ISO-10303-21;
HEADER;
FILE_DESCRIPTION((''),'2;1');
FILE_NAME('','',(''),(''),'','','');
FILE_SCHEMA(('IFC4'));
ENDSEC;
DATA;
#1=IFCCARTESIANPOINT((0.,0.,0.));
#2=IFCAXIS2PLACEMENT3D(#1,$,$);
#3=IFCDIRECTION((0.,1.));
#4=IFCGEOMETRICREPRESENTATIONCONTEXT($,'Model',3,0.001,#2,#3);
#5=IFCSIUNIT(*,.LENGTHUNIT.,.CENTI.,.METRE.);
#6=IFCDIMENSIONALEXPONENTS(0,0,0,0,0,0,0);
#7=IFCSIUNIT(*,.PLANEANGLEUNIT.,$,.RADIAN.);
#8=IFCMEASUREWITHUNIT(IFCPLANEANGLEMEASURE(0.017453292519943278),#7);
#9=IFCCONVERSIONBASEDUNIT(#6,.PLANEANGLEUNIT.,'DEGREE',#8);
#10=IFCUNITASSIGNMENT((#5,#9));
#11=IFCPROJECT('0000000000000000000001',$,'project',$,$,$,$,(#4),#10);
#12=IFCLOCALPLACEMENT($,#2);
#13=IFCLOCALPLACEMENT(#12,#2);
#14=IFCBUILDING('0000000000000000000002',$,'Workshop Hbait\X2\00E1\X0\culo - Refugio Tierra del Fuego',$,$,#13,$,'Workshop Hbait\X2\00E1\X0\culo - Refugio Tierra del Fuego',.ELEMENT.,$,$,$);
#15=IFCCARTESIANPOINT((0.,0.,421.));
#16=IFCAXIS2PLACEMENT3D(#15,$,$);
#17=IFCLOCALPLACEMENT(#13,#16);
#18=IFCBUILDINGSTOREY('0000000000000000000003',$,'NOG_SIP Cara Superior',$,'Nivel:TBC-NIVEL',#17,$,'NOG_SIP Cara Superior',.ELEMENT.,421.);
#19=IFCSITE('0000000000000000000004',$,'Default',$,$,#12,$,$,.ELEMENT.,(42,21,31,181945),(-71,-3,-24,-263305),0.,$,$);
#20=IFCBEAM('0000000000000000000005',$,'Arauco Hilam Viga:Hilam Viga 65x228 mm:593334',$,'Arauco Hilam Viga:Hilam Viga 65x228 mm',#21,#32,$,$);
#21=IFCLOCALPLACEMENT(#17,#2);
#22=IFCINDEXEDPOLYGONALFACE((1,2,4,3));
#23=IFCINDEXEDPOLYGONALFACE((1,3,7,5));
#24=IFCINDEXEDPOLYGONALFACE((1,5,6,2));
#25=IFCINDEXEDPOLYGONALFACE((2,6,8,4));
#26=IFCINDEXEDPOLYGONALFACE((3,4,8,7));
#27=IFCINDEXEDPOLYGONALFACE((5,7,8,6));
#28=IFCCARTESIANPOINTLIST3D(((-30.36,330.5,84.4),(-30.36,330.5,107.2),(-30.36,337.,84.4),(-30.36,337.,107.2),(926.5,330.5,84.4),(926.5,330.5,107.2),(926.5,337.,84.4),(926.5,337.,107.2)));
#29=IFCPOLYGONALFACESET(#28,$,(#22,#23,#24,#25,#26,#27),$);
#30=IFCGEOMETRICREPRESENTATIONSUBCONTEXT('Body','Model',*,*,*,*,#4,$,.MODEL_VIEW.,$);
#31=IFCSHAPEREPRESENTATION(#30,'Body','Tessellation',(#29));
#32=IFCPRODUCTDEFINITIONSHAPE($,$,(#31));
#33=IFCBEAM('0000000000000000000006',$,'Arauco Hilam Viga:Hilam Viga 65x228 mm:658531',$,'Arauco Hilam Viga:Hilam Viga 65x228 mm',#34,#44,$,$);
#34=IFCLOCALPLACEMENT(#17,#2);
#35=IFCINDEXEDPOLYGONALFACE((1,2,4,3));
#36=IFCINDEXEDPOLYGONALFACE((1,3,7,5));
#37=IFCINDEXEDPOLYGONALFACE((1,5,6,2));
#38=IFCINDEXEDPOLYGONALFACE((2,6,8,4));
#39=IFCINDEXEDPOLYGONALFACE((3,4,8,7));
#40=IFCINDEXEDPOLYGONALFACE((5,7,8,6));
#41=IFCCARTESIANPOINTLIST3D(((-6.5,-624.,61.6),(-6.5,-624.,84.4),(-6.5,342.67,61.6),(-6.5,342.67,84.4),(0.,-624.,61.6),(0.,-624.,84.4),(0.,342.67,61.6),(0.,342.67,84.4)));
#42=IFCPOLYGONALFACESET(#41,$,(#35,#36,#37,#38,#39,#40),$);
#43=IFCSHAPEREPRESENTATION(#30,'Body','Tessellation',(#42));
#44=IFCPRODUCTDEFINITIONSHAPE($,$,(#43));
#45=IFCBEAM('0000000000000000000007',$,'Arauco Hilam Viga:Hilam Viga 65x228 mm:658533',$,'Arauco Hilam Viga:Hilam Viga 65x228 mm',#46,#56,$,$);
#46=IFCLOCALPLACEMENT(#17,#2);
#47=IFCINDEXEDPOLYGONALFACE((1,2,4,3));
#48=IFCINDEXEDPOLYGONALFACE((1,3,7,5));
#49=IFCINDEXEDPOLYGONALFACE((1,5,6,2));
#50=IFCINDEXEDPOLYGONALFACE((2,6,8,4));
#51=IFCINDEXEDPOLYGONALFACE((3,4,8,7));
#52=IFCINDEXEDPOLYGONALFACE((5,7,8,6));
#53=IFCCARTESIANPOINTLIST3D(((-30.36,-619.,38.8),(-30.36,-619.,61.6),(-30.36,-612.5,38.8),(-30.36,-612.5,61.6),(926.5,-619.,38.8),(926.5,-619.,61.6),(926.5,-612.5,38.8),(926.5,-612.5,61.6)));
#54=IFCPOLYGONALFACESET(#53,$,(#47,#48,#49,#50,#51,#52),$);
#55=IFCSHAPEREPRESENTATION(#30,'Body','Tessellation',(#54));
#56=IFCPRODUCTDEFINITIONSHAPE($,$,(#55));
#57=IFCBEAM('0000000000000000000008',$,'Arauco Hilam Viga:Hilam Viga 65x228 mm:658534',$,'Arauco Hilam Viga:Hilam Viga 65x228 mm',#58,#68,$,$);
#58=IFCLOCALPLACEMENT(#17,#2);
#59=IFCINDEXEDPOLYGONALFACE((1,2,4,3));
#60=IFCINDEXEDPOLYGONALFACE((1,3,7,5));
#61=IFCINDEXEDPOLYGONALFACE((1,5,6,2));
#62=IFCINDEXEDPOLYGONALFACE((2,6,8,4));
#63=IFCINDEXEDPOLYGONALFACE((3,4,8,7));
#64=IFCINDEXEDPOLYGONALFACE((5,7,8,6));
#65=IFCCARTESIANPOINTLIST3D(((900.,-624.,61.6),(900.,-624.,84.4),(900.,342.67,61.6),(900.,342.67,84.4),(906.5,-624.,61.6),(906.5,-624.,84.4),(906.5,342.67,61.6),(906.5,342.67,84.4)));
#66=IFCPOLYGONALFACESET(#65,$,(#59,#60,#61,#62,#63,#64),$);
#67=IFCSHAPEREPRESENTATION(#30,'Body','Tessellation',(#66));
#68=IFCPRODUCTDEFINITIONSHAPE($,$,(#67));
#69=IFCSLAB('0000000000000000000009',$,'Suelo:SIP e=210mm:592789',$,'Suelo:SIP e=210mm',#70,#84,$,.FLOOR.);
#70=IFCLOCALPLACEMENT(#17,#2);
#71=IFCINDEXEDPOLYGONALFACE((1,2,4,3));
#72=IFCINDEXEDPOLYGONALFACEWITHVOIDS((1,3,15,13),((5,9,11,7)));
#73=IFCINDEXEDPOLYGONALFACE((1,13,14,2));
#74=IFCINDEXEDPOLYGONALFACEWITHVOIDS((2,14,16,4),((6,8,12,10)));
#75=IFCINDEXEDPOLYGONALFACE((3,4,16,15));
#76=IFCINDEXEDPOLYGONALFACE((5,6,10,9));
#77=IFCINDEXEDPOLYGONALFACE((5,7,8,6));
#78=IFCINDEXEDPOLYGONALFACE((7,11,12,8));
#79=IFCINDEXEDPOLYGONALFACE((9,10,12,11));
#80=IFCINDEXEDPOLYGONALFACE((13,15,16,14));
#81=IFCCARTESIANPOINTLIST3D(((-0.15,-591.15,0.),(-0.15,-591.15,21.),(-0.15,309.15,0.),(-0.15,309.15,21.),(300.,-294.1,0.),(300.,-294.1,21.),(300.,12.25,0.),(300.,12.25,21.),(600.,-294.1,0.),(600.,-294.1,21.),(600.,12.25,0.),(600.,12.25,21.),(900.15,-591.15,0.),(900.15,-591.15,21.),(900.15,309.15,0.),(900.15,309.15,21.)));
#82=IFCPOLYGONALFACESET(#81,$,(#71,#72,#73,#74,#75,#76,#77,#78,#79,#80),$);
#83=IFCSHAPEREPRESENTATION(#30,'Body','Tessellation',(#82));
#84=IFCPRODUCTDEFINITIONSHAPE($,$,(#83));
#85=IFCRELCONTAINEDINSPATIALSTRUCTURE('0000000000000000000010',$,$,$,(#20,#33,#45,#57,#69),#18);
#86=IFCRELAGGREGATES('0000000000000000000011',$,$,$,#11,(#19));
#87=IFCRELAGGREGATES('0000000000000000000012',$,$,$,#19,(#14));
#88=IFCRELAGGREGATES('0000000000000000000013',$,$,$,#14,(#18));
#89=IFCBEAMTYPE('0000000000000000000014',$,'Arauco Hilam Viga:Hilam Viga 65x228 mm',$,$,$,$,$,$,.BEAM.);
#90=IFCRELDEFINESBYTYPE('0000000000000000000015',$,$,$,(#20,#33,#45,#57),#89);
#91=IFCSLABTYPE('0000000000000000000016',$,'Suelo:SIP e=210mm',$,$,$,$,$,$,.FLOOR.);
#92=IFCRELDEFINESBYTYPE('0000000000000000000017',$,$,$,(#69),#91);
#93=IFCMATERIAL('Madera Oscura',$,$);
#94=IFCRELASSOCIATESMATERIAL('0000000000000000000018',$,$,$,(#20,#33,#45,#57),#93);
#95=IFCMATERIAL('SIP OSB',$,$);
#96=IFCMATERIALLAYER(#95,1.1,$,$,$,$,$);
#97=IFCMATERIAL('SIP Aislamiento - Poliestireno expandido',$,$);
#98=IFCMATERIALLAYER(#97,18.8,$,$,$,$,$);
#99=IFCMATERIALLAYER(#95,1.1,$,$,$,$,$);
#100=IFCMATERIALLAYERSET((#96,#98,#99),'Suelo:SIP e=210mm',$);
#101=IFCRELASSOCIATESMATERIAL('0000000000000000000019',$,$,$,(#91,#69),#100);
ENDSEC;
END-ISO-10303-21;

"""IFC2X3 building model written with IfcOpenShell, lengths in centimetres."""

from ifc_helpers import new_model, entity, si_unit, converted_unit, direction, frame, frame_2d, origin, origin_2d_with_axis, place, context, subcontext, project, spatial, rectangle, extrude, boolean, material, layer, layer_set, layer_usage, type_object, element, save


model = new_model("IFC2X3")

# Units and contexts
model_context = context("Model", 3, precision=0.001, world=origin(), true_north=direction((0.0, 1.0)))
body_context = subcontext(model_context, "Body", "Model", "MODEL_VIEW")
ifc_project = project(units=[si_unit("LENGTHUNIT", "METRE", prefix="CENTI"), converted_unit("PLANEANGLEUNIT", "DEGREE", entity("IfcPlaneAngleMeasure", 0.017453292519943278), si_unit("PLANEANGLEUNIT", "RADIAN"), dimensions=[0, 0, 0, 0, 0, 0, 0])], contexts=[model_context])

# Site, building, storey
site_placement = place(None, origin())
site = spatial("IfcSite", under=ifc_project, at=site_placement, Name="Default", CompositionType="ELEMENT", RefLatitude=(42, 21, 31, 181945), RefLongitude=(-71, -3, -24, -263305), RefElevation=0.0)
building_placement = place(site_placement, origin())
building = spatial("IfcBuilding", under=site, at=building_placement, Name="Workshop Hbaitáculo - Refugio Tierra del Fuego", LongName="Workshop Hbaitáculo - Refugio Tierra del Fuego", CompositionType="ELEMENT")
storey_placement = place(building_placement, frame((0.0, 0.0, 421.0)))
storey = spatial("IfcBuildingStorey", under=building, at=storey_placement, Name="NOG_SIP Cara Superior", ObjectType="Nivel:TBC-NIVEL", LongName="NOG_SIP Cara Superior", CompositionType="ELEMENT", Elevation=421.0)

# Beams
ifc_material_1 = material(Name="Madera Oscura")
beam_type = type_object("IfcBeamType", Name="Arauco Hilam Viga:Hilam Viga 65x228 mm", PredefinedType="BEAM")
beam_1_placement = place(storey_placement, frame((-96.14, 333.75, 107.2)))
element("IfcBeam", 1, at=beam_1_placement, inside=storey, type_object=beam_type, material=ifc_material_1, Name="Arauco Hilam Viga:Hilam Viga 65x228 mm:593334", ObjectType="Arauco Hilam Viga:Hilam Viga 65x228 mm", context=body_context, shape_type="SweptSolid", body=[
    extrude(rectangle(XDim=22.8, YDim=6.5, at=frame_2d((0.0, 0.0), x_axis=(1.0, 0.0))), frame((65.78, 0.0, -11.4), z_axis=(1.0, 0.0, 0.0), x_axis=(0.0, 0.0, -1.0)), (0.0, 0.0, 1.0), 956.86),
])
beam_2_placement = place(storey_placement, frame((-3.25, 318.11, 84.4), z_axis=(0.0, 0.0, 1.0), x_axis=(0.0, -1.0, 0.0)))
element("IfcBeam", 2, at=beam_2_placement, inside=storey, type_object=beam_type, material=ifc_material_1, Name="Arauco Hilam Viga:Hilam Viga 65x228 mm:658531", ObjectType="Arauco Hilam Viga:Hilam Viga 65x228 mm", context=body_context, shape_type="SweptSolid", body=[
    extrude(rectangle(XDim=22.8, YDim=6.5, at=frame_2d((0.0, 0.0), x_axis=(1.0, 0.0))), frame((-24.56, 0.0, -11.4), z_axis=(1.0, 0.0, 0.0), x_axis=(0.0, 0.0, -1.0)), (0.0, 0.0, 1.0), 966.67),
])
beam_3_placement = place(storey_placement, frame((-96.14, -615.75, 61.6)))
element("IfcBeam", 3, at=beam_3_placement, inside=storey, type_object=beam_type, material=ifc_material_1, Name="Arauco Hilam Viga:Hilam Viga 65x228 mm:658533", ObjectType="Arauco Hilam Viga:Hilam Viga 65x228 mm", context=body_context, shape_type="SweptSolid", body=[
    extrude(rectangle(XDim=22.8, YDim=6.5, at=origin_2d_with_axis()), frame((65.78, 0.0, -11.4), z_axis=(1.0, 0.0, 0.0), x_axis=(0.0, 0.0, -1.0)), (0.0, 0.0, 1.0), 956.86),
])
beam_4_placement = place(storey_placement, frame((903.25, 318.11, 84.4), z_axis=(0.0, 0.0, 1.0), x_axis=(0.0, -1.0, 0.0)))
element("IfcBeam", 4, at=beam_4_placement, inside=storey, type_object=beam_type, material=ifc_material_1, Name="Arauco Hilam Viga:Hilam Viga 65x228 mm:658534", ObjectType="Arauco Hilam Viga:Hilam Viga 65x228 mm", context=body_context, shape_type="SweptSolid", body=[
    extrude(rectangle(XDim=22.8, YDim=6.5, at=frame_2d((0.0, 0.0), x_axis=(1.0, 0.0))), frame((-24.56, 0.0, -11.4), z_axis=(1.0, 0.0, 0.0), x_axis=(0.0, 0.0, -1.0)), (0.0, 0.0, 1.0), 966.67),
])

# Slab, opening
ifc_material_2 = material(Name="SIP OSB")
ifc_layer_1 = layer(ifc_material_2, 1.1)
ifc_material_3 = material(Name="SIP Aislamiento - Poliestireno expandido")
ifc_layer_2 = layer(ifc_material_3, 18.8)
ifc_layer_3 = layer(ifc_material_2, 1.1)
ifc_layer_set = layer_set([ifc_layer_1, ifc_layer_2, ifc_layer_3], Name="Suelo:SIP e=210mm")
ifc_layer_usage = layer_usage(ifc_layer_set, "AXIS3", "POSITIVE", 0.0)
slab_type = type_object("IfcSlabType", Name="Suelo:SIP e=210mm", PredefinedType="FLOOR", material=ifc_layer_set)
slab_placement = place(storey_placement, origin())
slab = element("IfcSlab", 5, at=slab_placement, inside=storey, type_object=slab_type, material=ifc_layer_usage, Name="Suelo:SIP e=210mm:592789", ObjectType="Suelo:SIP e=210mm", PredefinedType="FLOOR", context=body_context, shape_type="CSG", body=[
    boolean("DIFFERENCE", extrude(rectangle(XDim=900.3, YDim=900.3, at=origin_2d_with_axis()), frame((450.0, -141.0, 21.0), z_axis=(0.0, 0.0, -1.0), x_axis=(0.0, 1.0, 0.0)), (0.0, 0.0, 1.0), 21.0), extrude(rectangle(XDim=306.35, YDim=300.0, at=frame_2d((0.0, 0.0), x_axis=(1.0, 0.0))), frame((450.0, -140.93, 0.0), z_axis=(0.0, 0.0, 1.0), x_axis=(0.0, 1.0, 0.0)), (0.0, 0.0, 1.0), 21.0)),
])
opening_placement = place(slab_placement, origin())
element("IfcOpeningElement", 6, at=opening_placement, cuts=slab, ObjectType="Opening", context=body_context, shape_type="SweptSolid", body=[
    extrude(rectangle(XDim=306.35, YDim=300.0, at=frame_2d((450.0, -140.93), x_axis=(0.0, -1.0))), frame((0.0, 0.0, 21.0)), (0.0, 0.0, -1.0), 21.0),
])

save(model, "model.ifc")
